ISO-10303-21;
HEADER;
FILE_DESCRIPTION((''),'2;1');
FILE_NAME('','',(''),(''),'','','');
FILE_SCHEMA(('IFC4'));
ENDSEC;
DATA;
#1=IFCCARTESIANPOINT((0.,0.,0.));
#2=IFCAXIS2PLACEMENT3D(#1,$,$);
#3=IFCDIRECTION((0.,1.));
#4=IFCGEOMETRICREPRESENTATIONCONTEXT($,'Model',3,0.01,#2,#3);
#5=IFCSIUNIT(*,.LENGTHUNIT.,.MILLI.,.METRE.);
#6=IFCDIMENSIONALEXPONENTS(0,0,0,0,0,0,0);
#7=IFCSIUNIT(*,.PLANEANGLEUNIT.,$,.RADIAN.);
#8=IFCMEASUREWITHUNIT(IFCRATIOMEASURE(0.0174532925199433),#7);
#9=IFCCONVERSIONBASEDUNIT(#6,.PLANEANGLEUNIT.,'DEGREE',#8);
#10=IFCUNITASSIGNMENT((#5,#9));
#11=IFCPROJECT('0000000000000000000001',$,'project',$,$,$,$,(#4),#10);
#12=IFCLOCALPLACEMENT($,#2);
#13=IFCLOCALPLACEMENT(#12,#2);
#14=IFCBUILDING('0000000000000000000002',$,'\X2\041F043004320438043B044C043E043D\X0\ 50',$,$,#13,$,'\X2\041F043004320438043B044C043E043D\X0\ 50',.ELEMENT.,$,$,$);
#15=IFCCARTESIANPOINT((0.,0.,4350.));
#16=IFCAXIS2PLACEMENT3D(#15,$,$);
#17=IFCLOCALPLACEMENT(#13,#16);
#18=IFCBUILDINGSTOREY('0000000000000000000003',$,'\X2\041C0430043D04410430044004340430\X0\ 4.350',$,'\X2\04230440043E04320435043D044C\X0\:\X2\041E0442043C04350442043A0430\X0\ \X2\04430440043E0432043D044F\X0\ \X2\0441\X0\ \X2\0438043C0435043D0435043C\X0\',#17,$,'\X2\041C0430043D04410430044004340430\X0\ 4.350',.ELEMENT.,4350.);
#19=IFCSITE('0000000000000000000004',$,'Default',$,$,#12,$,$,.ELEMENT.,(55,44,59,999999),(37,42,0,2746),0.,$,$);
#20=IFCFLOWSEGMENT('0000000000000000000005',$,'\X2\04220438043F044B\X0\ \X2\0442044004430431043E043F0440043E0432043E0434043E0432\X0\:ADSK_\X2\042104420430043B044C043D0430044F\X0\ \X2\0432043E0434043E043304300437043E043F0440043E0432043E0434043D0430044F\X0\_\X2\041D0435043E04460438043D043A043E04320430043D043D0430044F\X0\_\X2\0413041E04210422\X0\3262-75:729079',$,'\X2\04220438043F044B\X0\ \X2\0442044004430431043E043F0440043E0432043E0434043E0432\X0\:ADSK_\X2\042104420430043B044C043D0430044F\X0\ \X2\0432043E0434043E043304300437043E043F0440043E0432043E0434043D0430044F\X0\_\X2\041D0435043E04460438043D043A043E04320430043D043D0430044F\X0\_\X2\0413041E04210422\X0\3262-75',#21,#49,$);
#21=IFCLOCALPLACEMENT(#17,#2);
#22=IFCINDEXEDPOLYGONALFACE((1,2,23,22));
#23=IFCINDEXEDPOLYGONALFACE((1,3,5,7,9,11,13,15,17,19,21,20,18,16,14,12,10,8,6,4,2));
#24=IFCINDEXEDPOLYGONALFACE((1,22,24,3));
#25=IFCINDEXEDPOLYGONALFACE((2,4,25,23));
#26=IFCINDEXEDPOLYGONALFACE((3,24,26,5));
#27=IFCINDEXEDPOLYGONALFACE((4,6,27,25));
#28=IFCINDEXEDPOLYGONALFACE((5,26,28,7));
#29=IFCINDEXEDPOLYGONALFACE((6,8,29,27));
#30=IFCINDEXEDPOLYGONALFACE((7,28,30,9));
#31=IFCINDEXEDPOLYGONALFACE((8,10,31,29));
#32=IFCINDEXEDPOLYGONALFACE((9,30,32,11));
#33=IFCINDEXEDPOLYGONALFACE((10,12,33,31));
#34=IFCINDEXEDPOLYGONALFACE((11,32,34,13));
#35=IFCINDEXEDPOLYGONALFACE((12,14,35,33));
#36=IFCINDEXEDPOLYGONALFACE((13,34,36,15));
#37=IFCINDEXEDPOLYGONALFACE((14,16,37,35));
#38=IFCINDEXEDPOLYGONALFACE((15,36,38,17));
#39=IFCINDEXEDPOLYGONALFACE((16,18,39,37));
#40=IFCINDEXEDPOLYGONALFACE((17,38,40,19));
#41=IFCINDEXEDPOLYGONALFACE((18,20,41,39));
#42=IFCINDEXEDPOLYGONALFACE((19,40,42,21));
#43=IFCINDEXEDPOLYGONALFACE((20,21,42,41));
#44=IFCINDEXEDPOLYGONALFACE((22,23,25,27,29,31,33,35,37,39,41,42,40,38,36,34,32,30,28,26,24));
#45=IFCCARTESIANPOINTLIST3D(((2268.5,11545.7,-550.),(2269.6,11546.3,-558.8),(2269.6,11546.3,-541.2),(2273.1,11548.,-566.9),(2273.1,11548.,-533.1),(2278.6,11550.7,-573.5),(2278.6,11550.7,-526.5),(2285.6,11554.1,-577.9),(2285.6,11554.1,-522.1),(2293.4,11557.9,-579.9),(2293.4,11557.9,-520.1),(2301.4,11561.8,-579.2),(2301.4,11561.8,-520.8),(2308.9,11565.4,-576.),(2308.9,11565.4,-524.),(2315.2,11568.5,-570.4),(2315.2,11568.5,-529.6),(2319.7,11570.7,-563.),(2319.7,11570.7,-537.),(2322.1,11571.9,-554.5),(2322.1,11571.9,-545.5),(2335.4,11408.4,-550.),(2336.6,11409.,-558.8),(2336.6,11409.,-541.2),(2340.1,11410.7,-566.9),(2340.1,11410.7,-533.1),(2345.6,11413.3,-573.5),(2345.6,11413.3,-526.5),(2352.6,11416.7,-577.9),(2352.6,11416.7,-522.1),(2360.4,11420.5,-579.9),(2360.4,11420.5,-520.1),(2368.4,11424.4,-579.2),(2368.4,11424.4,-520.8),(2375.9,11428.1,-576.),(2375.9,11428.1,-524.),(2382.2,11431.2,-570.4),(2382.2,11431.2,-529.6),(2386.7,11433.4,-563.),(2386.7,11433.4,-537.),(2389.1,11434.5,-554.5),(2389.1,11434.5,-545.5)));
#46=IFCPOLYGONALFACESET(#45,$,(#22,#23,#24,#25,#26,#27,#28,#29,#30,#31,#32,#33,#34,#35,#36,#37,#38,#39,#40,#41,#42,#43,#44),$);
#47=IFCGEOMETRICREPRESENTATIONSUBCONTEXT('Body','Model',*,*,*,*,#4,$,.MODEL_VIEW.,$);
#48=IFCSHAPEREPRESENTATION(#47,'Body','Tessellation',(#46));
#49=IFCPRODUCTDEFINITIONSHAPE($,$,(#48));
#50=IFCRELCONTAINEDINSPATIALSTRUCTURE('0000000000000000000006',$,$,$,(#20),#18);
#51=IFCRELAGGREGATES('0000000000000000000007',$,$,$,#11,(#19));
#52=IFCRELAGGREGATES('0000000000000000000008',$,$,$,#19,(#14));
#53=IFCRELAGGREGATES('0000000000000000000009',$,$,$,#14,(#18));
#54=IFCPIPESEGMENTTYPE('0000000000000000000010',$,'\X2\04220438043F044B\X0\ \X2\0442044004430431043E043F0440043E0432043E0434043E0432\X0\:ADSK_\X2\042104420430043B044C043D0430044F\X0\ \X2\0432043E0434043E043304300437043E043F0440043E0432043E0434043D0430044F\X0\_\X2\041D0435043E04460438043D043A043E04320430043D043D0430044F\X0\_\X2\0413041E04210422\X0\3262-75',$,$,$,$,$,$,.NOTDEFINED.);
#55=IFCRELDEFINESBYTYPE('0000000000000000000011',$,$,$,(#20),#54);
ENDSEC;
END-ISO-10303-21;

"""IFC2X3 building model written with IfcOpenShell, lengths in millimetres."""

from ifc_helpers import new_model, entity, si_unit, converted_unit, direction, frame, frame_2d, origin, place, context, subcontext, project, spatial, circle, extrude, type_object, element, save


model = new_model("IFC2X3")

# Units and contexts
model_context = context("Model", 3, precision=0.01, world=origin(), true_north=direction((0.0, 1.0)))
body_context = subcontext(model_context, "Body", "Model", "MODEL_VIEW")
ifc_project = project(units=[si_unit("LENGTHUNIT", "METRE", prefix="MILLI"), converted_unit("PLANEANGLEUNIT", "DEGREE", entity("IfcRatioMeasure", 0.0174532925199433), si_unit("PLANEANGLEUNIT", "RADIAN"), dimensions=[0, 0, 0, 0, 0, 0, 0])], contexts=[model_context])

# Site, building, storey
site_placement = place(None, origin())
site = spatial("IfcSite", under=ifc_project, at=site_placement, Name="Default", CompositionType="ELEMENT", RefLatitude=(55, 44, 59, 999999), RefLongitude=(37, 42, 0, 2746), RefElevation=0.0)
building_placement = place(site_placement, origin())
building = spatial("IfcBuilding", under=site, at=building_placement, Name="Павильон 50", LongName="Павильон 50", CompositionType="ELEMENT")
storey_placement = place(building_placement, frame((0.0, 0.0, 4350.0)))
storey = spatial("IfcBuildingStorey", under=building, at=storey_placement, Name="Мансарда 4.350", ObjectType="Уровень:Отметка уровня с именем", LongName="Мансарда 4.350", CompositionType="ELEMENT", Elevation=4350.0)

# Flow segment
pipe_segment_type = type_object("IfcPipeSegmentType", Name="Типы трубопроводов:ADSK_Стальная водогазопроводная_Неоцинкованная_ГОСТ3262-75", PredefinedType="NOTDEFINED")
flow_segment_1_placement = place(storey_placement, frame((2266.9, 11406.8, -581.6)))
element("IfcFlowSegment", 1, at=flow_segment_1_placement, inside=storey, type_object=pipe_segment_type, Name="Типы трубопроводов:ADSK_Стальная водогазопроводная_Неоцинкованная_ГОСТ3262-75:729079", ObjectType="Типы трубопроводов:ADSK_Стальная водогазопроводная_Неоцинкованная_ГОСТ3262-75", context=body_context, shape_type="SweptSolid", body=[
    extrude(circle(Radius=30.0, at=frame_2d((0.0, 0.0), x_axis=(1.0, 0.0))), frame((28.6, 152.1, 31.6), z_axis=(0.438371, -0.898794, 0.0), x_axis=(-0.898794, -0.438371, 0.0)), (0.0, 0.0, 1.0), 152.8),
])

save(model, "model.ifc")
